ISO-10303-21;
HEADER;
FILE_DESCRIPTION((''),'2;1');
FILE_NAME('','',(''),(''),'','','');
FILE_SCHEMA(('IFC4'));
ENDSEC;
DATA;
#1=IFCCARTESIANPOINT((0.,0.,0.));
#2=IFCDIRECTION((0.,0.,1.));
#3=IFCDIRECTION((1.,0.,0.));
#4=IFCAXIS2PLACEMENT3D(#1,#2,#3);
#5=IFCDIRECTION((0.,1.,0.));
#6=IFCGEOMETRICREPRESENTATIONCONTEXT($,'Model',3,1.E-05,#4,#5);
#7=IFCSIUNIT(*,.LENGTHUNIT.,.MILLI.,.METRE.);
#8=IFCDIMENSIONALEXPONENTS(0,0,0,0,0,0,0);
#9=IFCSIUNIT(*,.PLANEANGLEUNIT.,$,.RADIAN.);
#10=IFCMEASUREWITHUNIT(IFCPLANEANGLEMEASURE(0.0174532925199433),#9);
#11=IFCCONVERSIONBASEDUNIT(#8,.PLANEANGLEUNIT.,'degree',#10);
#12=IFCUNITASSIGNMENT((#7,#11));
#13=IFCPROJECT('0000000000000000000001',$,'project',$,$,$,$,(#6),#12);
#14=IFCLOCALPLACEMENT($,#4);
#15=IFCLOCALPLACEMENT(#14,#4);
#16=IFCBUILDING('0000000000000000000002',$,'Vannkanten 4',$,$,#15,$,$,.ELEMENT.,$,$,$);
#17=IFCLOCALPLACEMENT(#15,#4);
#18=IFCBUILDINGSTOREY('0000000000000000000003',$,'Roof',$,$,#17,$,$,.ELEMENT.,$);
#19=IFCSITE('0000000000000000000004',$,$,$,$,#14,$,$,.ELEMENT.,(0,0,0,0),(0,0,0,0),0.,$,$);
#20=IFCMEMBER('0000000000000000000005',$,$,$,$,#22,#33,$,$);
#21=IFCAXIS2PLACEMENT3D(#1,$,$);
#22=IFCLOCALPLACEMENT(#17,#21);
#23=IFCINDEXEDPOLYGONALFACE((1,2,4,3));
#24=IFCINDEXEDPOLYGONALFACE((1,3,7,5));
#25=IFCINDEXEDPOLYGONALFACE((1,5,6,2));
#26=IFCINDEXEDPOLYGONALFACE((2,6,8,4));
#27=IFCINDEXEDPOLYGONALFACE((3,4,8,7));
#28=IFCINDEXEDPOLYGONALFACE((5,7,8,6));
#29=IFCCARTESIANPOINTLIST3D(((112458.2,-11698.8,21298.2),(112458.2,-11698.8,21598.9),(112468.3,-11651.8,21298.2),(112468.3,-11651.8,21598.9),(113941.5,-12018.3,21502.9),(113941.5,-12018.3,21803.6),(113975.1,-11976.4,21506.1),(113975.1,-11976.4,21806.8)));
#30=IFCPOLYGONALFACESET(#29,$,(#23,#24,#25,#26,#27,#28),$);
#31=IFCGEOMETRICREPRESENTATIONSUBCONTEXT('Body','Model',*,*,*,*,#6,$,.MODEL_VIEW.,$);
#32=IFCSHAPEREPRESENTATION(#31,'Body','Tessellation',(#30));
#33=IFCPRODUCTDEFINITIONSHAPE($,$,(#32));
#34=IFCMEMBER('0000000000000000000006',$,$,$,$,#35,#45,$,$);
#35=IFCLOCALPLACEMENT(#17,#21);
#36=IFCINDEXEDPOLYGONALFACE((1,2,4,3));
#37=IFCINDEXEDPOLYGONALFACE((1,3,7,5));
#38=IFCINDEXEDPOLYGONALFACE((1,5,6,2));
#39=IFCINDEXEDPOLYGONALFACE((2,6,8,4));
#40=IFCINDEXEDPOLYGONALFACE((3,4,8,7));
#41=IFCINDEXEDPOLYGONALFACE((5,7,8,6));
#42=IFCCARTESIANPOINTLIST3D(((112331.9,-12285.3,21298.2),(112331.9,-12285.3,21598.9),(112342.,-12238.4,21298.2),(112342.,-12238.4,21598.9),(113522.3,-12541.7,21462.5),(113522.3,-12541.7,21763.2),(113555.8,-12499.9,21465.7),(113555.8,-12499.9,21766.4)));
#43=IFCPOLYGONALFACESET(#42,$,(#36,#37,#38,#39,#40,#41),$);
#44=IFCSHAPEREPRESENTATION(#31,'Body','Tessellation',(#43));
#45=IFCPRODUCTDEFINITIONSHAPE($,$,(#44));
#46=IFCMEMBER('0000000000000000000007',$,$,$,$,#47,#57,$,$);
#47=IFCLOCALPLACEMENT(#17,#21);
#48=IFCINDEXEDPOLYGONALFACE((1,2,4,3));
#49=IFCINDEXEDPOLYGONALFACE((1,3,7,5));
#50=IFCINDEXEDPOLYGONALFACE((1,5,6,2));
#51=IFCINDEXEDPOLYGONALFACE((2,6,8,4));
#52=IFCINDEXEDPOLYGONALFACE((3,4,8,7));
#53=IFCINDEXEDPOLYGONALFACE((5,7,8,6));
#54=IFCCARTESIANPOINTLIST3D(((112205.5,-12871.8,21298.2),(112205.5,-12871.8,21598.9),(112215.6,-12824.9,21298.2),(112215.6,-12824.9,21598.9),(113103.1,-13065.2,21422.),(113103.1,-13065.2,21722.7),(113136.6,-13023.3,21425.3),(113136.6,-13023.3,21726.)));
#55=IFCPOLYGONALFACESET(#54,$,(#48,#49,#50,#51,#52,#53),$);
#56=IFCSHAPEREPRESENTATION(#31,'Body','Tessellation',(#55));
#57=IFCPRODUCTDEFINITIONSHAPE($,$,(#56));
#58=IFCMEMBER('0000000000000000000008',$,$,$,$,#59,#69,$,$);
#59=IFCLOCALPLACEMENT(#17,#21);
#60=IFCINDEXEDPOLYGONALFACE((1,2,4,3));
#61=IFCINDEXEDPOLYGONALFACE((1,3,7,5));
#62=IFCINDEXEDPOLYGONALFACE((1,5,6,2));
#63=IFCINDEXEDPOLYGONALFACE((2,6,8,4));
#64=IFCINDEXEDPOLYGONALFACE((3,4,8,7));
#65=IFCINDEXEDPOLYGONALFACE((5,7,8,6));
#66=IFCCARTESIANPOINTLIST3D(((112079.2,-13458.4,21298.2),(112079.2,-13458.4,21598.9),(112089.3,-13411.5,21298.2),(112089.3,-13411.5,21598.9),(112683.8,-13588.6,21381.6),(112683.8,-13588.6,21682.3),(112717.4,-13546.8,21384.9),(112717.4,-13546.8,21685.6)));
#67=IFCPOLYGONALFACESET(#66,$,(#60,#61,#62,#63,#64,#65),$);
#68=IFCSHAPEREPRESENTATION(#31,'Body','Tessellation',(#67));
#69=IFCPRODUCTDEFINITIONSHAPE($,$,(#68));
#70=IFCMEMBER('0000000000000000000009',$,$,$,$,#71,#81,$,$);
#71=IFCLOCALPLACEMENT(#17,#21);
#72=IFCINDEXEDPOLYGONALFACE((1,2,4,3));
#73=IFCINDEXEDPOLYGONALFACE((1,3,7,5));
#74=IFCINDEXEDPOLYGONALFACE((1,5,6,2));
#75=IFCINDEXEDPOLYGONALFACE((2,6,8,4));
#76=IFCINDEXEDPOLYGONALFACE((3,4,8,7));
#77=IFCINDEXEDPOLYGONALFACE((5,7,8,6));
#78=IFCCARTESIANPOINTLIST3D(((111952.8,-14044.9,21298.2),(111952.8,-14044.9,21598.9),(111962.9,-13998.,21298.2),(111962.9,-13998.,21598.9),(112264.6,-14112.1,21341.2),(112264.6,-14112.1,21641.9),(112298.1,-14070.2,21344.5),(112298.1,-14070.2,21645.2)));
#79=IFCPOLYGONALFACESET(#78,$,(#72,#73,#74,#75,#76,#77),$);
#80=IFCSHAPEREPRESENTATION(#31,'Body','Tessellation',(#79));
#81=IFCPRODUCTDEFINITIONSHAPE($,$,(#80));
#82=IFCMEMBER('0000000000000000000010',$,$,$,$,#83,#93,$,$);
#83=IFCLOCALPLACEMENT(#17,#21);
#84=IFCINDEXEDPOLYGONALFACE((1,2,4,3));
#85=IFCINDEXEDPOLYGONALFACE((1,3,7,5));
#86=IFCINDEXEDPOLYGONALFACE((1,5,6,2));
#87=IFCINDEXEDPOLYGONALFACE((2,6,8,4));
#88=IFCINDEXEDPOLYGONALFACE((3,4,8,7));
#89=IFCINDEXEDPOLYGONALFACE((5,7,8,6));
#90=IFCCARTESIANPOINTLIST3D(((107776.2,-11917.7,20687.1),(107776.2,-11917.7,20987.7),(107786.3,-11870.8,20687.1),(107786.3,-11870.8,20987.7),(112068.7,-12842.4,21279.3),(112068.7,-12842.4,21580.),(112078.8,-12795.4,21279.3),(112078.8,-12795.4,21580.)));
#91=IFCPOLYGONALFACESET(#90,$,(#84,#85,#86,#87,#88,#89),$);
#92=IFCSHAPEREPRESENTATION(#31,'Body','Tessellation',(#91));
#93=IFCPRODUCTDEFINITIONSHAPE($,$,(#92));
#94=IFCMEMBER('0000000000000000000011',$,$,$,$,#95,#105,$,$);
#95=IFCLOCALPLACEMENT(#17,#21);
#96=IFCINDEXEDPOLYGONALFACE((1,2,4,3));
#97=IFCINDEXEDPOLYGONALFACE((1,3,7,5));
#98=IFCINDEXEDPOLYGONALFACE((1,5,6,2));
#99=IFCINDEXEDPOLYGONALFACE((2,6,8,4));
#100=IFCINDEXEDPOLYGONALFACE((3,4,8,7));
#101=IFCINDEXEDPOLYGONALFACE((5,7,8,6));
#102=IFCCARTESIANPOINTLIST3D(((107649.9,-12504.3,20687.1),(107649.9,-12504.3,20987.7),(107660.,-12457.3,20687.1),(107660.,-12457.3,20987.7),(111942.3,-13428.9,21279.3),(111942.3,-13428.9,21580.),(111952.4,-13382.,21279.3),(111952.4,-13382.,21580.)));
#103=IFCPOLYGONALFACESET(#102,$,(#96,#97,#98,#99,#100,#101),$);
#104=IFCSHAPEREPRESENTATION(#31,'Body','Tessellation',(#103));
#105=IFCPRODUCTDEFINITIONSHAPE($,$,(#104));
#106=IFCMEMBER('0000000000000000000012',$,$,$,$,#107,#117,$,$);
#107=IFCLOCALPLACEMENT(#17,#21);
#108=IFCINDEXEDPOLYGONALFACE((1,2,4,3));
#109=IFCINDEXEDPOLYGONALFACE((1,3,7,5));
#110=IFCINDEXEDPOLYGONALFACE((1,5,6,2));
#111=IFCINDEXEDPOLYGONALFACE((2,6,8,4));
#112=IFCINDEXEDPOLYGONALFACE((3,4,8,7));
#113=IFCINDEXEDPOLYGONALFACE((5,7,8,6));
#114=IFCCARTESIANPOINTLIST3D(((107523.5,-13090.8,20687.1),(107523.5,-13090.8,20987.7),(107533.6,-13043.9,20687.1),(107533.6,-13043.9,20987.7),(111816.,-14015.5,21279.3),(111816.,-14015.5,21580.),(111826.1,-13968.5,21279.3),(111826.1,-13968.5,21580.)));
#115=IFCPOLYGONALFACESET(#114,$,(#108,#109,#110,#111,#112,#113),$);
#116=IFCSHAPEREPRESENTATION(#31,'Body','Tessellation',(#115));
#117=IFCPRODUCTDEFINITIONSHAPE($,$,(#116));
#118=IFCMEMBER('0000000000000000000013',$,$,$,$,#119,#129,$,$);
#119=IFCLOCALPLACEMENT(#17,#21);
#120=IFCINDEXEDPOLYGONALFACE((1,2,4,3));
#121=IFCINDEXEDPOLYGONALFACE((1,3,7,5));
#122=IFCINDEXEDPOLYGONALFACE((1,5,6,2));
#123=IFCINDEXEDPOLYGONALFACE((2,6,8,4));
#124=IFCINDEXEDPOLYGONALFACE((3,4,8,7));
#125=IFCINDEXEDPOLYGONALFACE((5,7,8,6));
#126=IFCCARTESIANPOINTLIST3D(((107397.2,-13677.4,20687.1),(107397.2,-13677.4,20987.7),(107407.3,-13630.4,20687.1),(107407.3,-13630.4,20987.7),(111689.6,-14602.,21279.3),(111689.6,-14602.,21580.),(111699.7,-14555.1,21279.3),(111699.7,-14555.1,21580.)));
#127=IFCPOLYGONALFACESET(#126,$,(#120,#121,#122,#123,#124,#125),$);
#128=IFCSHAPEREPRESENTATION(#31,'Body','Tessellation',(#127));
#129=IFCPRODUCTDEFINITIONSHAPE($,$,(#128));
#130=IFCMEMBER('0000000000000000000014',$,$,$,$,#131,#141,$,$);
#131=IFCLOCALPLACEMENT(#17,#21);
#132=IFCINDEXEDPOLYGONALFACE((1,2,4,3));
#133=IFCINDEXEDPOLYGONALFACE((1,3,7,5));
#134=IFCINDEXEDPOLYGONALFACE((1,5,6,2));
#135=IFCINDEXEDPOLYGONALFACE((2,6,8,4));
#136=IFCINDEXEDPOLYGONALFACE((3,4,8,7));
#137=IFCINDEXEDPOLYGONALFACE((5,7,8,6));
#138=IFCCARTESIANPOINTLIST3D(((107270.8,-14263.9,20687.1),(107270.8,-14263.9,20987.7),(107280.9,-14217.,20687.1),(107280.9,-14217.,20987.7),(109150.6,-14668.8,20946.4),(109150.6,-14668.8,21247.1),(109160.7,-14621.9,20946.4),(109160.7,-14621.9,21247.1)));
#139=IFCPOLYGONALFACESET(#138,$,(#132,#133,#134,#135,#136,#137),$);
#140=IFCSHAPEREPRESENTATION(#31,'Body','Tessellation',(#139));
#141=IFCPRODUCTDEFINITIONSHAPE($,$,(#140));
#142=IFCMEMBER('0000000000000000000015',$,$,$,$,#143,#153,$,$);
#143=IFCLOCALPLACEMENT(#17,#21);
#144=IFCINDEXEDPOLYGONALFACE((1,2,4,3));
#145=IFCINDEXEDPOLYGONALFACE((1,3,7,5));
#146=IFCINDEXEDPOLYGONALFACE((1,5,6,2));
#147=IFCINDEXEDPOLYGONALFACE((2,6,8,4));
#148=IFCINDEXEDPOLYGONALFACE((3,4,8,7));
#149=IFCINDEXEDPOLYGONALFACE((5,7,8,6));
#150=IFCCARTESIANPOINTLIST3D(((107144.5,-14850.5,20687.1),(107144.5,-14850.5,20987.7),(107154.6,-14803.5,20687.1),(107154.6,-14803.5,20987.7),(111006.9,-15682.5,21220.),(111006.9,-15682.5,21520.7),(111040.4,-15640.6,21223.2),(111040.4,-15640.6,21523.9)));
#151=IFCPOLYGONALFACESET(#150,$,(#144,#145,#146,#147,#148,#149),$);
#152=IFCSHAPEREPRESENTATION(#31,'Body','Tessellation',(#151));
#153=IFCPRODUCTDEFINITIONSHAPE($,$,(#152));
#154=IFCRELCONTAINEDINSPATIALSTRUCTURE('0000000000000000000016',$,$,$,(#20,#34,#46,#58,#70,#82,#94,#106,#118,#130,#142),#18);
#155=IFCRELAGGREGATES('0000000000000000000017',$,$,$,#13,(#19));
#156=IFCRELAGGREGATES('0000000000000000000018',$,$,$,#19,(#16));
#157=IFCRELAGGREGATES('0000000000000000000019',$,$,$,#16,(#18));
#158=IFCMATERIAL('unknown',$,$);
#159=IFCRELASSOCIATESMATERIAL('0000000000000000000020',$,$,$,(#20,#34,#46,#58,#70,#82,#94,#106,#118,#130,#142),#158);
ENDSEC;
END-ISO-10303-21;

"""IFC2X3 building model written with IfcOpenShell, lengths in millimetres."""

from ifc_helpers import new_model, entity, si_unit, converted_unit, direction, frame, origin_with_axes, place, context, subcontext, project, spatial, polyline, segment, composite_curve, outline, extrude, clip, halfspace, material, element, save


model = new_model("IFC2X3")

# Units and contexts
model_context = context("Model", 3, precision=1e-05, world=origin_with_axes(), true_north=direction((0.0, 1.0, 0.0)))
body_context = subcontext(model_context, "Body", "Model", "MODEL_VIEW")
ifc_project = project(units=[si_unit("LENGTHUNIT", "METRE", prefix="MILLI"), converted_unit("PLANEANGLEUNIT", "degree", entity("IfcPlaneAngleMeasure", 0.0174532925199433), si_unit("PLANEANGLEUNIT", "RADIAN"), dimensions=[0, 0, 0, 0, 0, 0, 0])], contexts=[model_context])

# Site, building, storey
site_placement = place(None, origin_with_axes())
site = spatial("IfcSite", under=ifc_project, at=site_placement, CompositionType="ELEMENT", RefLatitude=(0, 0, 0, 0), RefLongitude=(0, 0, 0, 0), RefElevation=0.0)
building_placement = place(site_placement, origin_with_axes())
building = spatial("IfcBuilding", under=site, at=building_placement, Name="Vannkanten 4", CompositionType="ELEMENT")
storey_placement = place(building_placement, origin_with_axes())
storey = spatial("IfcBuildingStorey", under=building, at=storey_placement, Name="Roof", CompositionType="ELEMENT")

# Members
ifc_material = material(Name="unknown")
member_1_placement = place(storey_placement, frame((112463.3, -11675.3, 21448.6), z_axis=(0.968803, -0.208692, 0.133675), x_axis=(0.210582, 0.977576, 0.0)))
element("IfcMember", 1, at=member_1_placement, inside=storey, material=ifc_material, context=body_context, shape_type="Clipping", body=[
    clip(clip(extrude(outline(composite_curve([segment(polyline([(-24.0, -149.0), (-24.0, 149.0), (24.0, 149.0), (24.0, -149.0), (-24.0, -149.0)]), True, "CONTINUOUS")], self_intersect=False)), frame((0.0, 0.0, -817.8), z_axis=(0.0, 0.0, 1.0), x_axis=(1.0, 0.0, 0.0)), (0.0, 0.0, 1.0), 3190.9), halfspace(frame((-24.0, 149.0, 20.1), z_axis=(0.0, -0.133675, 0.991025), x_axis=(0.0, 0.991025, 0.133675)), True)), halfspace(frame((24.0, 149.0, 1575.4), z_axis=(0.446741, 0.119594, -0.886634), x_axis=(-0.893044, 0.0, -0.44997)), True)),
])
member_2_placement = place(storey_placement, frame((112336.9, -12261.8, 21448.6), z_axis=(0.968803, -0.208692, 0.133675), x_axis=(0.210582, 0.977576, 0.0)))
element("IfcMember", 2, at=member_2_placement, inside=storey, material=ifc_material, context=body_context, shape_type="Clipping", body=[
    clip(clip(extrude(outline(composite_curve([segment(polyline([(-24.0, -149.0), (-24.0, 149.0), (24.0, 149.0), (24.0, -149.0), (-24.0, -149.0)]), True, "CONTINUOUS")], self_intersect=False)), frame((0.0, 0.0, -666.7), z_axis=(0.0, 0.0, 1.0), x_axis=(1.0, 0.0, 0.0)), (0.0, 0.0, 1.0), 2586.3), halfspace(frame((-24.0, 149.0, 20.1), z_axis=(0.0, -0.133675, 0.991025), x_axis=(0.0, 0.991025, 0.133675)), True)), halfspace(frame((24.0, 149.0, 1273.0), z_axis=(0.446741, 0.119594, -0.886634), x_axis=(-0.893044, 0.0, -0.44997)), True)),
])
member_3_placement = place(storey_placement, frame((112210.6, -12848.4, 21448.6), z_axis=(0.968803, -0.208692, 0.133675), x_axis=(0.210582, 0.977576, 0.0)))
element("IfcMember", 3, at=member_3_placement, inside=storey, material=ifc_material, context=body_context, shape_type="Clipping", body=[
    clip(clip(extrude(outline(composite_curve([segment(polyline([(-24.0, -149.0), (-24.0, 149.0), (24.0, 149.0), (24.0, -149.0), (-24.0, -149.0)]), True, "CONTINUOUS")], self_intersect=False)), frame((0.0, 0.0, -515.5), z_axis=(0.0, 0.0, 1.0), x_axis=(1.0, 0.0, 0.0)), (0.0, 0.0, 1.0), 1981.6), halfspace(frame((-24.0, 149.0, 20.1), z_axis=(0.0, -0.133675, 0.991025), x_axis=(0.0, 0.991025, 0.133675)), True)), halfspace(frame((24.0, 149.0, 970.7), z_axis=(0.446741, 0.119594, -0.886634), x_axis=(-0.893044, 0.0, -0.44997)), True)),
])
member_4_placement = place(storey_placement, frame((112084.2, -13434.9, 21448.6), z_axis=(0.968803, -0.208692, 0.133675), x_axis=(0.210582, 0.977576, 0.0)))
element("IfcMember", 4, at=member_4_placement, inside=storey, material=ifc_material, context=body_context, shape_type="Clipping", body=[
    clip(clip(extrude(outline(composite_curve([segment(polyline([(-24.0, -149.0), (-24.0, 149.0), (24.0, 149.0), (24.0, -149.0), (-24.0, -149.0)]), True, "CONTINUOUS")], self_intersect=False)), frame((0.0, 0.0, -364.4), z_axis=(0.0, 0.0, 1.0), x_axis=(1.0, 0.0, 0.0)), (0.0, 0.0, 1.0), 1377.0), halfspace(frame((-24.0, 149.0, 20.1), z_axis=(0.0, -0.133675, 0.991025), x_axis=(0.0, 0.991025, 0.133675)), True)), halfspace(frame((24.0, 149.0, 668.4), z_axis=(0.446741, 0.119594, -0.886634), x_axis=(-0.893044, 0.0, -0.44997)), True)),
])
member_5_placement = place(storey_placement, frame((111957.9, -14021.5, 21448.6), z_axis=(0.968803, -0.208692, 0.133675), x_axis=(0.210582, 0.977576, 0.0)))
element("IfcMember", 5, at=member_5_placement, inside=storey, material=ifc_material, context=body_context, shape_type="Clipping", body=[
    clip(clip(extrude(outline(composite_curve([segment(polyline([(-24.0, -149.0), (-24.0, 149.0), (24.0, 149.0), (24.0, -149.0), (-24.0, -149.0)]), True, "CONTINUOUS")], self_intersect=False)), frame((0.0, 0.0, -213.2), z_axis=(0.0, 0.0, 1.0), x_axis=(1.0, 0.0, 0.0)), (0.0, 0.0, 1.0), 772.4), halfspace(frame((-24.0, 149.0, 20.1), z_axis=(0.0, -0.133675, 0.991025), x_axis=(0.0, 0.991025, 0.133675)), True)), halfspace(frame((24.0, 149.0, 366.1), z_axis=(0.446741, 0.119594, -0.886634), x_axis=(-0.893044, 0.0, -0.44997)), True)),
])
member_6_placement = place(storey_placement, frame((107781.3, -11894.3, 20837.4), z_axis=(0.968803, -0.208692, 0.133675), x_axis=(0.210582, 0.977576, 0.0)))
element("IfcMember", 6, at=member_6_placement, inside=storey, material=ifc_material, context=body_context, shape_type="Clipping", body=[
    clip(clip(extrude(outline(composite_curve([segment(polyline([(-24.0, -149.0), (-24.0, 149.0), (24.0, 149.0), (24.0, -149.0), (-24.0, -149.0)]), True, "CONTINUOUS")], self_intersect=False)), frame((0.0, 0.0, -2255.5), z_axis=(0.0, 0.0, 1.0), x_axis=(1.0, 0.0, 0.0)), (0.0, 0.0, 1.0), 8941.7), halfspace(frame((-24.0, 149.0, 20.1), z_axis=(0.0, -0.133675, 0.991025), x_axis=(0.0, 0.991025, 0.133675)), True)), halfspace(frame((24.0, 149.0, 4450.8), z_axis=(0.0, 0.133675, -0.991025), x_axis=(0.0, -0.991025, -0.133675)), True)),
])
member_7_placement = place(storey_placement, frame((107654.9, -12480.8, 20837.4), z_axis=(0.968803, -0.208692, 0.133675), x_axis=(0.210582, 0.977576, 0.0)))
element("IfcMember", 7, at=member_7_placement, inside=storey, material=ifc_material, context=body_context, shape_type="Clipping", body=[
    clip(clip(extrude(outline(composite_curve([segment(polyline([(-24.0, -149.0), (-24.0, 149.0), (24.0, 149.0), (24.0, -149.0), (-24.0, -149.0)]), True, "CONTINUOUS")], self_intersect=False)), frame((0.0, 0.0, -2255.5), z_axis=(0.0, 0.0, 1.0), x_axis=(1.0, 0.0, 0.0)), (0.0, 0.0, 1.0), 8941.7), halfspace(frame((-24.0, 149.0, 20.1), z_axis=(0.0, -0.133675, 0.991025), x_axis=(0.0, 0.991025, 0.133675)), True)), halfspace(frame((24.0, 149.0, 4450.8), z_axis=(0.0, 0.133675, -0.991025), x_axis=(0.0, -0.991025, -0.133675)), True)),
])
member_8_placement = place(storey_placement, frame((107528.6, -13067.4, 20837.4), z_axis=(0.968803, -0.208692, 0.133675), x_axis=(0.210582, 0.977576, 0.0)))
element("IfcMember", 8, at=member_8_placement, inside=storey, material=ifc_material, context=body_context, shape_type="Clipping", body=[
    clip(clip(extrude(outline(composite_curve([segment(polyline([(-24.0, -149.0), (-24.0, 149.0), (24.0, 149.0), (24.0, -149.0), (-24.0, -149.0)]), True, "CONTINUOUS")], self_intersect=False)), frame((0.0, 0.0, -2255.5), z_axis=(0.0, 0.0, 1.0), x_axis=(1.0, 0.0, 0.0)), (0.0, 0.0, 1.0), 8941.7), halfspace(frame((-24.0, 149.0, 20.1), z_axis=(0.0, -0.133675, 0.991025), x_axis=(0.0, 0.991025, 0.133675)), True)), halfspace(frame((24.0, 149.0, 4450.8), z_axis=(0.0, 0.133675, -0.991025), x_axis=(0.0, -0.991025, -0.133675)), True)),
])
member_9_placement = place(storey_placement, frame((107402.2, -13653.9, 20837.4), z_axis=(0.968803, -0.208692, 0.133675), x_axis=(0.210582, 0.977576, 0.0)))
element("IfcMember", 9, at=member_9_placement, inside=storey, material=ifc_material, context=body_context, shape_type="Clipping", body=[
    clip(clip(extrude(outline(composite_curve([segment(polyline([(-24.0, -149.0), (-24.0, 149.0), (24.0, 149.0), (24.0, -149.0), (-24.0, -149.0)]), True, "CONTINUOUS")], self_intersect=False)), frame((0.0, 0.0, -2255.5), z_axis=(0.0, 0.0, 1.0), x_axis=(1.0, 0.0, 0.0)), (0.0, 0.0, 1.0), 8941.7), halfspace(frame((-24.0, 149.0, 20.1), z_axis=(0.0, -0.133675, 0.991025), x_axis=(0.0, 0.991025, 0.133675)), True)), halfspace(frame((24.0, 149.0, 4450.8), z_axis=(0.0, 0.133675, -0.991025), x_axis=(0.0, -0.991025, -0.133675)), True)),
])
member_10_placement = place(storey_placement, frame((107275.9, -14240.4, 20837.4), z_axis=(0.968803, -0.208692, 0.133675), x_axis=(0.210582, 0.977576, 0.0)))
element("IfcMember", 10, at=member_10_placement, inside=storey, material=ifc_material, context=body_context, shape_type="Clipping", body=[
    clip(clip(extrude(outline(composite_curve([segment(polyline([(-24.0, -149.0), (-24.0, 149.0), (24.0, 149.0), (24.0, -149.0), (-24.0, -149.0)]), True, "CONTINUOUS")], self_intersect=False)), frame((0.0, 0.0, -1010.4), z_axis=(0.0, 0.0, 1.0), x_axis=(1.0, 0.0, 0.0)), (0.0, 0.0, 1.0), 3961.0), halfspace(frame((-24.0, 149.0, 20.1), z_axis=(0.0, -0.133675, 0.991025), x_axis=(0.0, 0.991025, 0.133675)), True)), halfspace(frame((24.0, 149.0, 1960.4), z_axis=(0.0, 0.133675, -0.991025), x_axis=(0.0, -0.991025, -0.133675)), True)),
])
member_11_placement = place(storey_placement, frame((107149.5, -14827.0, 20837.4), z_axis=(0.968803, -0.208692, 0.133675), x_axis=(0.210582, 0.977576, 0.0)))
element("IfcMember", 11, at=member_11_placement, inside=storey, material=ifc_material, context=body_context, shape_type="Clipping", body=[
    clip(clip(extrude(outline(composite_curve([segment(polyline([(-24.0, -149.0), (-24.0, 149.0), (24.0, 149.0), (24.0, -149.0), (-24.0, -149.0)]), True, "CONTINUOUS")], self_intersect=False)), frame((0.0, 0.0, -2045.7), z_axis=(0.0, 0.0, 1.0), x_axis=(1.0, 0.0, 0.0)), (0.0, 0.0, 1.0), 8102.3), halfspace(frame((-24.0, 149.0, 20.1), z_axis=(0.0, -0.133675, 0.991025), x_axis=(0.0, 0.991025, 0.133675)), True)), halfspace(frame((24.0, 149.0, 4031.1), z_axis=(0.446741, 0.119594, -0.886634), x_axis=(-0.893044, 0.0, -0.44997)), True)),
])

save(model, "model.ifc")
